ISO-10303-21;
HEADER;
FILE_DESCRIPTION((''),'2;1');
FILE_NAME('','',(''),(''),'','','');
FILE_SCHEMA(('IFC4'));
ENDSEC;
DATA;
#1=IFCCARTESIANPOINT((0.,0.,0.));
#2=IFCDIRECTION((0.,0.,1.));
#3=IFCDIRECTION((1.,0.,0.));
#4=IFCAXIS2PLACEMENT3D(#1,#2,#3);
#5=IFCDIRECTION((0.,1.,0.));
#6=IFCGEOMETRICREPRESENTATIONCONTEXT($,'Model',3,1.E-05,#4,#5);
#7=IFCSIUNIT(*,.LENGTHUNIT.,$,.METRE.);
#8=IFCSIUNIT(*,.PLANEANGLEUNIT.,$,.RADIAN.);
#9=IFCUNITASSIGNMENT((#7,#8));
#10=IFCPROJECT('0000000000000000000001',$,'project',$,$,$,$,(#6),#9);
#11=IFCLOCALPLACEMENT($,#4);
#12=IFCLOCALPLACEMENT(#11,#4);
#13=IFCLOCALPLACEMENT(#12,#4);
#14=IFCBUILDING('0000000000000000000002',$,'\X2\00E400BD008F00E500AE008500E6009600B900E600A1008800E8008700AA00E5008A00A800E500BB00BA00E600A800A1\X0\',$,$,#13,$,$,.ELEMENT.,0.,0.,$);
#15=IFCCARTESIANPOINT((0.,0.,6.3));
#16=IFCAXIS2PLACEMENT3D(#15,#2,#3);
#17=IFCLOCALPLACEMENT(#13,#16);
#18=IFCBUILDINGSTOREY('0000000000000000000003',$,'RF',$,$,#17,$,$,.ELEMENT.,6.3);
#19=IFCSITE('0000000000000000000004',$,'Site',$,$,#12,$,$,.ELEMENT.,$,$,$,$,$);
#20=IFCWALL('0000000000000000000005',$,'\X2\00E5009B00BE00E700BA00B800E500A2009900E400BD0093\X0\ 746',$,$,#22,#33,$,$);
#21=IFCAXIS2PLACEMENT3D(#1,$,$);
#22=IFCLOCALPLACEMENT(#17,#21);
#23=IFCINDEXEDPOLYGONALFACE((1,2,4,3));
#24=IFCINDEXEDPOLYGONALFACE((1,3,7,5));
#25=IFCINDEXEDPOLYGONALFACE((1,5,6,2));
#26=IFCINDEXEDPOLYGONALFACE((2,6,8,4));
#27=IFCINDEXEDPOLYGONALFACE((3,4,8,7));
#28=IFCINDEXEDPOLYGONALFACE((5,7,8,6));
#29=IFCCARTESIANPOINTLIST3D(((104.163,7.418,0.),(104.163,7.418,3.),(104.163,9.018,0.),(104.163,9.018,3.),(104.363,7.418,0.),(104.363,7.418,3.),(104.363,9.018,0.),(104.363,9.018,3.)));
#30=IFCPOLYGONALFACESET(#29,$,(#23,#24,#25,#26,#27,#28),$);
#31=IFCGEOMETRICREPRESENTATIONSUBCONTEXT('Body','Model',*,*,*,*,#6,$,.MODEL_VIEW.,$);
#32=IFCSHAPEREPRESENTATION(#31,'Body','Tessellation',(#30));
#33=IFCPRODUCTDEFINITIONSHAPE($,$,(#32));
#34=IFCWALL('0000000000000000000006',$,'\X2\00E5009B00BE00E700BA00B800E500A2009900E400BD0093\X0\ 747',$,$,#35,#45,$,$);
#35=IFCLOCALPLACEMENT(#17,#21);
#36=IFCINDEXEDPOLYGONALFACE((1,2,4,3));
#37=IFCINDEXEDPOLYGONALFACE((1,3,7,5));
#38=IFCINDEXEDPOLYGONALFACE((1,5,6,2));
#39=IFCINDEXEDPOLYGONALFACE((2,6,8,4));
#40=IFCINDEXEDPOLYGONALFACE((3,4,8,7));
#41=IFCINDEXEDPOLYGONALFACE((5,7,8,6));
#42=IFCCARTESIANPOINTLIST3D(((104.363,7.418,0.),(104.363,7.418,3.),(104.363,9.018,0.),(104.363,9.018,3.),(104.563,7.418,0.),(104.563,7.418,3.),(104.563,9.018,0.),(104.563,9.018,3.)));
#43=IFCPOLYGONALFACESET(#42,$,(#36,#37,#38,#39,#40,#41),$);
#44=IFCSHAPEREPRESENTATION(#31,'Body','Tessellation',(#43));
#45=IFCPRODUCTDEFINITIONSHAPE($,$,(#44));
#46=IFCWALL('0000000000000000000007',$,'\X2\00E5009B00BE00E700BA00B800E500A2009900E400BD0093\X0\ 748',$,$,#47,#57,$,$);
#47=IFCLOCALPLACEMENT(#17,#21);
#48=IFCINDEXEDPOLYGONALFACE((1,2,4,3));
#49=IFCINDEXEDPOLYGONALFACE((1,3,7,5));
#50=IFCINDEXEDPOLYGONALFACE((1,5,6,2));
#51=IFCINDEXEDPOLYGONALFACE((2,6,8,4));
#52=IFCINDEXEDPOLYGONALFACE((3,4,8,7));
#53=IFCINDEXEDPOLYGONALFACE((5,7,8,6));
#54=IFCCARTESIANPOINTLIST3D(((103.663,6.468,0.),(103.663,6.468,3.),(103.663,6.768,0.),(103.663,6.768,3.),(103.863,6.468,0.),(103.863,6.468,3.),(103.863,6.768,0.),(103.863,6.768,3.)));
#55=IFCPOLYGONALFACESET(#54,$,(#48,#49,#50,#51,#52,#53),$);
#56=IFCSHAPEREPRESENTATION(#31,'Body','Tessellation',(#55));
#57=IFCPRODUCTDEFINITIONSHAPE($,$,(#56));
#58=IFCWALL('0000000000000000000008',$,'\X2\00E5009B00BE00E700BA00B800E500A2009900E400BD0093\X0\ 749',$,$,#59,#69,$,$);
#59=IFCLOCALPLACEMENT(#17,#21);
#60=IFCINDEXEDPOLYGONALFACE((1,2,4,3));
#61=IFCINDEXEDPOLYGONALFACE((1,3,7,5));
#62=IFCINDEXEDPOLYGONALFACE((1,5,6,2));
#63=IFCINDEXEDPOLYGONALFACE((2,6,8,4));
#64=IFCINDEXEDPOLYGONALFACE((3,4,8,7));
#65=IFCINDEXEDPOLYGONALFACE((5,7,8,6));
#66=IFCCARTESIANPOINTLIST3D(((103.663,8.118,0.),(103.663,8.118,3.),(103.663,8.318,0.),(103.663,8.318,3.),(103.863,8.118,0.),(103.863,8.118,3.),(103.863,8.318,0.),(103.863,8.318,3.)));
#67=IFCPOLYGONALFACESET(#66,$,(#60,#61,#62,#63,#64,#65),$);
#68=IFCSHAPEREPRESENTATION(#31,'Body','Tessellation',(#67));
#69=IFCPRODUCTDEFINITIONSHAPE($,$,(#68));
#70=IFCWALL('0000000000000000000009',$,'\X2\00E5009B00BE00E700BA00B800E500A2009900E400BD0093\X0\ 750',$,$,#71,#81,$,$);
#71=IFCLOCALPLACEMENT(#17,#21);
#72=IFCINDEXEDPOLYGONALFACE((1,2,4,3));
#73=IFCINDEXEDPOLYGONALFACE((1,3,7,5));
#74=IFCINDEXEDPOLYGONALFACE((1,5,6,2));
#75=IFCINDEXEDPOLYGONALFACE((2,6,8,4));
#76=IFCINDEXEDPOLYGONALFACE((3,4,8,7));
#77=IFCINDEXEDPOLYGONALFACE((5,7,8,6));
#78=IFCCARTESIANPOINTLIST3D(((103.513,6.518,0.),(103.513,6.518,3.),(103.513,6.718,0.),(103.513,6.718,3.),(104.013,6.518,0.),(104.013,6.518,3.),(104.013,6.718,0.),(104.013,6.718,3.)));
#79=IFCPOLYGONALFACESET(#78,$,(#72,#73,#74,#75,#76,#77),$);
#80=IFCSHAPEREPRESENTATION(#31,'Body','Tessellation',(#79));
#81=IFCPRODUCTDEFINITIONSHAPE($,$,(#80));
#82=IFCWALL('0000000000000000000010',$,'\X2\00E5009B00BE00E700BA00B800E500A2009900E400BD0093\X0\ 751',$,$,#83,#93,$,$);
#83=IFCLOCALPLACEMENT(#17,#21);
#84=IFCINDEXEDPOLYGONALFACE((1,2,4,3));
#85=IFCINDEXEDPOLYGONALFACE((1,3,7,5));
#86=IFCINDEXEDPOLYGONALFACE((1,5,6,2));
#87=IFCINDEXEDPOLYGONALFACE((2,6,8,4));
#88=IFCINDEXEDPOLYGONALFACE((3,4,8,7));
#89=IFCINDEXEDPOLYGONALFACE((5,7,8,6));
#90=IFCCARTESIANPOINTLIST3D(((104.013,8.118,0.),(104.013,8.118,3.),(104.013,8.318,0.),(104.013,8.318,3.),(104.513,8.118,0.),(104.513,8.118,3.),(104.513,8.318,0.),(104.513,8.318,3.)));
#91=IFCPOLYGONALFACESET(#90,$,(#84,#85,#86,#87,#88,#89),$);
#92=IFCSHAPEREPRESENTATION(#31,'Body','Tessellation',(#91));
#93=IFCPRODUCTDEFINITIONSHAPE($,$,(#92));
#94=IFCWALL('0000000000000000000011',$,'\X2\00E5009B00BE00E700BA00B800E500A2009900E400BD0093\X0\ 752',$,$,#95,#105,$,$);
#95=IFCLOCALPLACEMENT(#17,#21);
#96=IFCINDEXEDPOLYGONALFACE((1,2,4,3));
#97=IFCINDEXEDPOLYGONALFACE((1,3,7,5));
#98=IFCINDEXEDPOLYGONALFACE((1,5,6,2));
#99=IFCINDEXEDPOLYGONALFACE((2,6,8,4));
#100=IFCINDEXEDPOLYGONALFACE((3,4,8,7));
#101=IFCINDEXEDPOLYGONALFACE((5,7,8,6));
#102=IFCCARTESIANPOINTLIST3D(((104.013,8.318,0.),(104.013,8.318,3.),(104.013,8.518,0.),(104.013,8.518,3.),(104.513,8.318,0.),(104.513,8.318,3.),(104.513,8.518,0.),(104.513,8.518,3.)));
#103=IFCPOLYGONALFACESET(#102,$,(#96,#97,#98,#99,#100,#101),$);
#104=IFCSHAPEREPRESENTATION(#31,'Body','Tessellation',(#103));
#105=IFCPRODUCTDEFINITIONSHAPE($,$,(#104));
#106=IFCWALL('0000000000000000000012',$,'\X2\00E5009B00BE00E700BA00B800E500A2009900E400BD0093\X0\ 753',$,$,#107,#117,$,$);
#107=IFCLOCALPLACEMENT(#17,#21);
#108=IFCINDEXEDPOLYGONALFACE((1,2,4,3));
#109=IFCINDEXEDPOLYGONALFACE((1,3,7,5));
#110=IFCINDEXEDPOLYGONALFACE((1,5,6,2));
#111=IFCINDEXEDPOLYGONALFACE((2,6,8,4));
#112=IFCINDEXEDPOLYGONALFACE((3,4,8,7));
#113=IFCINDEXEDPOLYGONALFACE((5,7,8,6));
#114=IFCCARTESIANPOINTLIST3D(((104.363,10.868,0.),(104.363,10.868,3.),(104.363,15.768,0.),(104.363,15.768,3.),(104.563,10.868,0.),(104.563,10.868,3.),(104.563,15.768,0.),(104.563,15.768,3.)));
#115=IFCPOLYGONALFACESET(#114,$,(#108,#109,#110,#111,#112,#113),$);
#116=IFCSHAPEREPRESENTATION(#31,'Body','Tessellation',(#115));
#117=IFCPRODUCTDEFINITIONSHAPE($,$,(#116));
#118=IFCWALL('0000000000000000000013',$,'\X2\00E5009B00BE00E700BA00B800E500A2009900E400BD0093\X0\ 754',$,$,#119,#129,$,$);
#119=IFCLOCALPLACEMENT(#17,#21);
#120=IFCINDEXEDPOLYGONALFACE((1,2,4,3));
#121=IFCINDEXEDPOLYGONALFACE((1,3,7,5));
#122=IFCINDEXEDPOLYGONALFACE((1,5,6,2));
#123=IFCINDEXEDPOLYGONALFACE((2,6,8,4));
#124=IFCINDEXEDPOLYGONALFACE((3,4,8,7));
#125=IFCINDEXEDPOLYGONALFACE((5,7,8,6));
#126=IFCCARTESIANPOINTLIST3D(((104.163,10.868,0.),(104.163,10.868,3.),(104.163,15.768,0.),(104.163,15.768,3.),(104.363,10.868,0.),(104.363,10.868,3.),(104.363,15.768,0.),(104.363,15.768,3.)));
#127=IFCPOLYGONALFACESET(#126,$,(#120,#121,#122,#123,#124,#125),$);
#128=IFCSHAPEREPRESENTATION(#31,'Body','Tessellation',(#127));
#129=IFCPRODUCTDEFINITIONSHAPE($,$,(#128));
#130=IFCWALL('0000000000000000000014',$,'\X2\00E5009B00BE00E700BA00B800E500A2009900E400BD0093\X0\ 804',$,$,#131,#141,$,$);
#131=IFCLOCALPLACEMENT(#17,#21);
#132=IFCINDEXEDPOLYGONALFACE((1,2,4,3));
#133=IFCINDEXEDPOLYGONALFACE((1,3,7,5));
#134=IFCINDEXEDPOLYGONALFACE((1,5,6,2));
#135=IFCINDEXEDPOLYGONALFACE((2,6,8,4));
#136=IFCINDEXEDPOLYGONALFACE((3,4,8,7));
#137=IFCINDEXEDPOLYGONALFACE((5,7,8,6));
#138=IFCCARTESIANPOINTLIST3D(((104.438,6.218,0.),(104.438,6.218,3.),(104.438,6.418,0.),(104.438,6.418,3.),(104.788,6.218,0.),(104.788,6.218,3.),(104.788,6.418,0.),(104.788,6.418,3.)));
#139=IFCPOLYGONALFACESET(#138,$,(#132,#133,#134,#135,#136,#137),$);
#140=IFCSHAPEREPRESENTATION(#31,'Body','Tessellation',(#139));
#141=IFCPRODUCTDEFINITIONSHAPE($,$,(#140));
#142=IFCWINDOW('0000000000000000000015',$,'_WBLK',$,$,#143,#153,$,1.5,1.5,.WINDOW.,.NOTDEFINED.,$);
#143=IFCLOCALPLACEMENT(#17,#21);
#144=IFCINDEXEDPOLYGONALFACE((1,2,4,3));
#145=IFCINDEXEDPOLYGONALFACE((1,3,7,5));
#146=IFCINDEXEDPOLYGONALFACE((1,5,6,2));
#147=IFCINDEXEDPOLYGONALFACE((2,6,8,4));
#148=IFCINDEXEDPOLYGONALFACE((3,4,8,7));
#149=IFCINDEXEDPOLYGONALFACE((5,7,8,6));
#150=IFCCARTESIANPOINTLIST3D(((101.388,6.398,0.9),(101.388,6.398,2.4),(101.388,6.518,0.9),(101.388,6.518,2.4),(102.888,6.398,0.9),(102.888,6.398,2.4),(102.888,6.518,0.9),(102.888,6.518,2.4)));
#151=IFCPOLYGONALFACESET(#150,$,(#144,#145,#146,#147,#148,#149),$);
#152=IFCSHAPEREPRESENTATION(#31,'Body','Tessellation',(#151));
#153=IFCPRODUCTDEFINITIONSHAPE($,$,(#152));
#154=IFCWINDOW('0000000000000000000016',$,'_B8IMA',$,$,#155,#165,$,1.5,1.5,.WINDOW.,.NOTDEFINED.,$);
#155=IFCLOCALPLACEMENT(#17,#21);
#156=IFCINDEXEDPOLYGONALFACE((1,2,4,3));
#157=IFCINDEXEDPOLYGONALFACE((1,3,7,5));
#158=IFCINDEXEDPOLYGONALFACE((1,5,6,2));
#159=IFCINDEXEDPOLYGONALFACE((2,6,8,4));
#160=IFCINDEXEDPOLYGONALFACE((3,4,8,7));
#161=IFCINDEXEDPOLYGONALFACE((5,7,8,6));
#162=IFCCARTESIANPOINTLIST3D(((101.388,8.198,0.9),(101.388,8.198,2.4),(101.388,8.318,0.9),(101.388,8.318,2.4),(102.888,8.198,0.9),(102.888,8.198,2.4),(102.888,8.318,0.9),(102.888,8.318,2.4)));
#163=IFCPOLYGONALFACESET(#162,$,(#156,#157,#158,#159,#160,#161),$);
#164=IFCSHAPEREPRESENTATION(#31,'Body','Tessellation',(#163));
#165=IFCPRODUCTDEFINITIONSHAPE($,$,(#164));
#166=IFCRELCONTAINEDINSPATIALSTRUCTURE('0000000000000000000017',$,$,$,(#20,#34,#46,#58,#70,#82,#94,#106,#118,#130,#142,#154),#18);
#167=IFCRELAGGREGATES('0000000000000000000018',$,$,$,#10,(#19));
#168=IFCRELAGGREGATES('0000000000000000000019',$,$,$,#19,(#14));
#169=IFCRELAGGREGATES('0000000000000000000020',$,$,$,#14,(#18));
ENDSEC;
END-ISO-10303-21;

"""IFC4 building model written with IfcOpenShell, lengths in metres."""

from ifc_helpers import new_model, si_unit, direction, frame, frame_2d, origin_with_axes, place, context, subcontext, project, spatial, rectangle, extrude, element, save


model = new_model("IFC4")

# Units and contexts
model_context = context("Model", 3, precision=1e-05, world=origin_with_axes(), true_north=direction((0.0, 1.0, 0.0)))
body_context = subcontext(model_context, "Body", "Model", "MODEL_VIEW")
ifc_project = project(units=[si_unit("LENGTHUNIT", "METRE"), si_unit("PLANEANGLEUNIT", "RADIAN")], contexts=[model_context])

# Site, building, storey
placement = place(None, origin_with_axes())
site_placement = place(placement, origin_with_axes())
site = spatial("IfcSite", under=ifc_project, at=site_placement, Name="Site", CompositionType="ELEMENT")
building_placement = place(site_placement, origin_with_axes())
building = spatial("IfcBuilding", under=site, at=building_placement, Name="ä½\u008få®\u0085æ\u0096¹æ¡\u0088è\u0087ªå\u008a¨å»ºæ¨¡", CompositionType="ELEMENT", ElevationOfRefHeight=0.0, ElevationOfTerrain=0.0)
storey_placement = place(building_placement, frame((0.0, 0.0, 6.3), z_axis=(0.0, 0.0, 1.0), x_axis=(1.0, 0.0, 0.0)))
storey = spatial("IfcBuildingStorey", under=building, at=storey_placement, Name="RF", CompositionType="ELEMENT", Elevation=6.3)

# Walls
for number, where, z_axis, x_axis, name in (
    (1, (104.263, 8.218, 0.0), (0.0, 0.0, 1.0), (0.0, -1.0, 0.0), "å\u009b¾çº¸å¢\u0099ä½\u0093 746"),
    (2, (104.463, 8.218, 0.0), (0.0, 0.0, 1.0), (0.0, -1.0, 0.0), "å\u009b¾çº¸å¢\u0099ä½\u0093 747"),
):
    element("IfcWall", number, at=place(storey_placement, frame(where, z_axis=z_axis, x_axis=x_axis)), inside=storey, Name=name, context=body_context, shape_type="SweptSolid", body=[
        extrude(rectangle(XDim=1.6, YDim=0.2, at=frame_2d((0.0, 0.0), x_axis=(1.0, 0.0, 0.0))), frame((0.0, 0.0, 0.0), z_axis=(0.0, 0.0, 1.0)), (0.0, 0.0, 1.0), 3.0),
    ])
wall_1_placement = place(storey_placement, frame((103.763, 6.618, 0.0), z_axis=(0.0, 0.0, 1.0), x_axis=(0.0, -1.0, 0.0)))
element("IfcWall", 3, at=wall_1_placement, inside=storey, Name="å\u009b¾çº¸å¢\u0099ä½\u0093 748", context=body_context, shape_type="SweptSolid", body=[
    extrude(rectangle(XDim=0.3, YDim=0.2, at=frame_2d((0.0, 0.0), x_axis=(1.0, 0.0, 0.0))), frame((0.0, 0.0, 0.0), z_axis=(0.0, 0.0, 1.0)), (0.0, 0.0, 1.0), 3.0),
])
wall_2_placement = place(storey_placement, frame((103.763, 8.218, 0.0), z_axis=(0.0, 0.0, 1.0), x_axis=(0.0, 1.0, 0.0)))
element("IfcWall", 4, at=wall_2_placement, inside=storey, Name="å\u009b¾çº¸å¢\u0099ä½\u0093 749", context=body_context, shape_type="SweptSolid", body=[
    extrude(rectangle(XDim=0.2, YDim=0.2, at=frame_2d((0.0, 0.0), x_axis=(1.0, 0.0, 0.0))), frame((0.0, 0.0, 0.0), z_axis=(0.0, 0.0, 1.0)), (0.0, 0.0, 1.0), 3.0),
])
for number, where, z_axis, x_axis, name in (
    (5, (103.763, 6.618, 0.0), (0.0, 0.0, 1.0), (1.0, 0.0, 0.0), "å\u009b¾çº¸å¢\u0099ä½\u0093 750"),
    (6, (104.263, 8.218, 0.0), (0.0, 0.0, 1.0), (-1.0, 0.0, 0.0), "å\u009b¾çº¸å¢\u0099ä½\u0093 751"),
    (7, (104.263, 8.418, 0.0), (0.0, 0.0, 1.0), (-1.0, 0.0, 0.0), "å\u009b¾çº¸å¢\u0099ä½\u0093 752"),
):
    element("IfcWall", number, at=place(storey_placement, frame(where, z_axis=z_axis, x_axis=x_axis)), inside=storey, Name=name, context=body_context, shape_type="SweptSolid", body=[
        extrude(rectangle(XDim=0.5, YDim=0.2, at=frame_2d((0.0, 0.0), x_axis=(1.0, 0.0, 0.0))), frame((0.0, 0.0, 0.0), z_axis=(0.0, 0.0, 1.0)), (0.0, 0.0, 1.0), 3.0),
    ])
for number, where, z_axis, x_axis, name in (
    (8, (104.463, 13.318, 0.0), (0.0, 0.0, 1.0), (0.0, -1.0, 0.0), "å\u009b¾çº¸å¢\u0099ä½\u0093 753"),
    (9, (104.263, 13.318, 0.0), (0.0, 0.0, 1.0), (0.0, -1.0, 0.0), "å\u009b¾çº¸å¢\u0099ä½\u0093 754"),
):
    element("IfcWall", number, at=place(storey_placement, frame(where, z_axis=z_axis, x_axis=x_axis)), inside=storey, Name=name, context=body_context, shape_type="SweptSolid", body=[
        extrude(rectangle(XDim=4.9, YDim=0.2, at=frame_2d((0.0, 0.0), x_axis=(1.0, 0.0, 0.0))), frame((0.0, 0.0, 0.0), z_axis=(0.0, 0.0, 1.0)), (0.0, 0.0, 1.0), 3.0),
    ])
wall_3_placement = place(storey_placement, frame((104.613, 6.318, 0.0), z_axis=(0.0, 0.0, 1.0), x_axis=(1.0, 0.0, 0.0)))
element("IfcWall", 10, at=wall_3_placement, inside=storey, Name="å\u009b¾çº¸å¢\u0099ä½\u0093 804", context=body_context, shape_type="SweptSolid", body=[
    extrude(rectangle(XDim=0.35, YDim=0.2, at=frame_2d((0.0, 0.0), x_axis=(1.0, 0.0, 0.0))), frame((0.0, 0.0, 0.0), z_axis=(0.0, 0.0, 1.0)), (0.0, 0.0, 1.0), 3.0),
])

# Windows
for number, where, z_axis, x_axis, name in (
    (11, (102.138, 6.458, 0.9), (0.0, 0.0, 1.0), (1.0, 0.0, 0.0), "_WBLK"),
    (12, (102.138, 8.258, 0.9), (0.0, 0.0, 1.0), (1.0, 0.0, 0.0), "_B8IMA"),
):
    element("IfcWindow", number, at=place(storey_placement, frame(where, z_axis=z_axis, x_axis=x_axis)), inside=storey, Name=name, OverallHeight=1.5, OverallWidth=1.5, PartitioningType="NOTDEFINED", PredefinedType="WINDOW", context=body_context, shape_type="SweptSolid", body=[
        extrude(rectangle(XDim=1.5, YDim=0.12, at=frame_2d((0.0, 0.0), x_axis=(1.0, 0.0, 0.0))), frame((0.0, 0.0, 0.0), z_axis=(0.0, 0.0, 1.0)), (0.0, 0.0, 1.0), 1.5),
    ])

save(model, "model.ifc")
